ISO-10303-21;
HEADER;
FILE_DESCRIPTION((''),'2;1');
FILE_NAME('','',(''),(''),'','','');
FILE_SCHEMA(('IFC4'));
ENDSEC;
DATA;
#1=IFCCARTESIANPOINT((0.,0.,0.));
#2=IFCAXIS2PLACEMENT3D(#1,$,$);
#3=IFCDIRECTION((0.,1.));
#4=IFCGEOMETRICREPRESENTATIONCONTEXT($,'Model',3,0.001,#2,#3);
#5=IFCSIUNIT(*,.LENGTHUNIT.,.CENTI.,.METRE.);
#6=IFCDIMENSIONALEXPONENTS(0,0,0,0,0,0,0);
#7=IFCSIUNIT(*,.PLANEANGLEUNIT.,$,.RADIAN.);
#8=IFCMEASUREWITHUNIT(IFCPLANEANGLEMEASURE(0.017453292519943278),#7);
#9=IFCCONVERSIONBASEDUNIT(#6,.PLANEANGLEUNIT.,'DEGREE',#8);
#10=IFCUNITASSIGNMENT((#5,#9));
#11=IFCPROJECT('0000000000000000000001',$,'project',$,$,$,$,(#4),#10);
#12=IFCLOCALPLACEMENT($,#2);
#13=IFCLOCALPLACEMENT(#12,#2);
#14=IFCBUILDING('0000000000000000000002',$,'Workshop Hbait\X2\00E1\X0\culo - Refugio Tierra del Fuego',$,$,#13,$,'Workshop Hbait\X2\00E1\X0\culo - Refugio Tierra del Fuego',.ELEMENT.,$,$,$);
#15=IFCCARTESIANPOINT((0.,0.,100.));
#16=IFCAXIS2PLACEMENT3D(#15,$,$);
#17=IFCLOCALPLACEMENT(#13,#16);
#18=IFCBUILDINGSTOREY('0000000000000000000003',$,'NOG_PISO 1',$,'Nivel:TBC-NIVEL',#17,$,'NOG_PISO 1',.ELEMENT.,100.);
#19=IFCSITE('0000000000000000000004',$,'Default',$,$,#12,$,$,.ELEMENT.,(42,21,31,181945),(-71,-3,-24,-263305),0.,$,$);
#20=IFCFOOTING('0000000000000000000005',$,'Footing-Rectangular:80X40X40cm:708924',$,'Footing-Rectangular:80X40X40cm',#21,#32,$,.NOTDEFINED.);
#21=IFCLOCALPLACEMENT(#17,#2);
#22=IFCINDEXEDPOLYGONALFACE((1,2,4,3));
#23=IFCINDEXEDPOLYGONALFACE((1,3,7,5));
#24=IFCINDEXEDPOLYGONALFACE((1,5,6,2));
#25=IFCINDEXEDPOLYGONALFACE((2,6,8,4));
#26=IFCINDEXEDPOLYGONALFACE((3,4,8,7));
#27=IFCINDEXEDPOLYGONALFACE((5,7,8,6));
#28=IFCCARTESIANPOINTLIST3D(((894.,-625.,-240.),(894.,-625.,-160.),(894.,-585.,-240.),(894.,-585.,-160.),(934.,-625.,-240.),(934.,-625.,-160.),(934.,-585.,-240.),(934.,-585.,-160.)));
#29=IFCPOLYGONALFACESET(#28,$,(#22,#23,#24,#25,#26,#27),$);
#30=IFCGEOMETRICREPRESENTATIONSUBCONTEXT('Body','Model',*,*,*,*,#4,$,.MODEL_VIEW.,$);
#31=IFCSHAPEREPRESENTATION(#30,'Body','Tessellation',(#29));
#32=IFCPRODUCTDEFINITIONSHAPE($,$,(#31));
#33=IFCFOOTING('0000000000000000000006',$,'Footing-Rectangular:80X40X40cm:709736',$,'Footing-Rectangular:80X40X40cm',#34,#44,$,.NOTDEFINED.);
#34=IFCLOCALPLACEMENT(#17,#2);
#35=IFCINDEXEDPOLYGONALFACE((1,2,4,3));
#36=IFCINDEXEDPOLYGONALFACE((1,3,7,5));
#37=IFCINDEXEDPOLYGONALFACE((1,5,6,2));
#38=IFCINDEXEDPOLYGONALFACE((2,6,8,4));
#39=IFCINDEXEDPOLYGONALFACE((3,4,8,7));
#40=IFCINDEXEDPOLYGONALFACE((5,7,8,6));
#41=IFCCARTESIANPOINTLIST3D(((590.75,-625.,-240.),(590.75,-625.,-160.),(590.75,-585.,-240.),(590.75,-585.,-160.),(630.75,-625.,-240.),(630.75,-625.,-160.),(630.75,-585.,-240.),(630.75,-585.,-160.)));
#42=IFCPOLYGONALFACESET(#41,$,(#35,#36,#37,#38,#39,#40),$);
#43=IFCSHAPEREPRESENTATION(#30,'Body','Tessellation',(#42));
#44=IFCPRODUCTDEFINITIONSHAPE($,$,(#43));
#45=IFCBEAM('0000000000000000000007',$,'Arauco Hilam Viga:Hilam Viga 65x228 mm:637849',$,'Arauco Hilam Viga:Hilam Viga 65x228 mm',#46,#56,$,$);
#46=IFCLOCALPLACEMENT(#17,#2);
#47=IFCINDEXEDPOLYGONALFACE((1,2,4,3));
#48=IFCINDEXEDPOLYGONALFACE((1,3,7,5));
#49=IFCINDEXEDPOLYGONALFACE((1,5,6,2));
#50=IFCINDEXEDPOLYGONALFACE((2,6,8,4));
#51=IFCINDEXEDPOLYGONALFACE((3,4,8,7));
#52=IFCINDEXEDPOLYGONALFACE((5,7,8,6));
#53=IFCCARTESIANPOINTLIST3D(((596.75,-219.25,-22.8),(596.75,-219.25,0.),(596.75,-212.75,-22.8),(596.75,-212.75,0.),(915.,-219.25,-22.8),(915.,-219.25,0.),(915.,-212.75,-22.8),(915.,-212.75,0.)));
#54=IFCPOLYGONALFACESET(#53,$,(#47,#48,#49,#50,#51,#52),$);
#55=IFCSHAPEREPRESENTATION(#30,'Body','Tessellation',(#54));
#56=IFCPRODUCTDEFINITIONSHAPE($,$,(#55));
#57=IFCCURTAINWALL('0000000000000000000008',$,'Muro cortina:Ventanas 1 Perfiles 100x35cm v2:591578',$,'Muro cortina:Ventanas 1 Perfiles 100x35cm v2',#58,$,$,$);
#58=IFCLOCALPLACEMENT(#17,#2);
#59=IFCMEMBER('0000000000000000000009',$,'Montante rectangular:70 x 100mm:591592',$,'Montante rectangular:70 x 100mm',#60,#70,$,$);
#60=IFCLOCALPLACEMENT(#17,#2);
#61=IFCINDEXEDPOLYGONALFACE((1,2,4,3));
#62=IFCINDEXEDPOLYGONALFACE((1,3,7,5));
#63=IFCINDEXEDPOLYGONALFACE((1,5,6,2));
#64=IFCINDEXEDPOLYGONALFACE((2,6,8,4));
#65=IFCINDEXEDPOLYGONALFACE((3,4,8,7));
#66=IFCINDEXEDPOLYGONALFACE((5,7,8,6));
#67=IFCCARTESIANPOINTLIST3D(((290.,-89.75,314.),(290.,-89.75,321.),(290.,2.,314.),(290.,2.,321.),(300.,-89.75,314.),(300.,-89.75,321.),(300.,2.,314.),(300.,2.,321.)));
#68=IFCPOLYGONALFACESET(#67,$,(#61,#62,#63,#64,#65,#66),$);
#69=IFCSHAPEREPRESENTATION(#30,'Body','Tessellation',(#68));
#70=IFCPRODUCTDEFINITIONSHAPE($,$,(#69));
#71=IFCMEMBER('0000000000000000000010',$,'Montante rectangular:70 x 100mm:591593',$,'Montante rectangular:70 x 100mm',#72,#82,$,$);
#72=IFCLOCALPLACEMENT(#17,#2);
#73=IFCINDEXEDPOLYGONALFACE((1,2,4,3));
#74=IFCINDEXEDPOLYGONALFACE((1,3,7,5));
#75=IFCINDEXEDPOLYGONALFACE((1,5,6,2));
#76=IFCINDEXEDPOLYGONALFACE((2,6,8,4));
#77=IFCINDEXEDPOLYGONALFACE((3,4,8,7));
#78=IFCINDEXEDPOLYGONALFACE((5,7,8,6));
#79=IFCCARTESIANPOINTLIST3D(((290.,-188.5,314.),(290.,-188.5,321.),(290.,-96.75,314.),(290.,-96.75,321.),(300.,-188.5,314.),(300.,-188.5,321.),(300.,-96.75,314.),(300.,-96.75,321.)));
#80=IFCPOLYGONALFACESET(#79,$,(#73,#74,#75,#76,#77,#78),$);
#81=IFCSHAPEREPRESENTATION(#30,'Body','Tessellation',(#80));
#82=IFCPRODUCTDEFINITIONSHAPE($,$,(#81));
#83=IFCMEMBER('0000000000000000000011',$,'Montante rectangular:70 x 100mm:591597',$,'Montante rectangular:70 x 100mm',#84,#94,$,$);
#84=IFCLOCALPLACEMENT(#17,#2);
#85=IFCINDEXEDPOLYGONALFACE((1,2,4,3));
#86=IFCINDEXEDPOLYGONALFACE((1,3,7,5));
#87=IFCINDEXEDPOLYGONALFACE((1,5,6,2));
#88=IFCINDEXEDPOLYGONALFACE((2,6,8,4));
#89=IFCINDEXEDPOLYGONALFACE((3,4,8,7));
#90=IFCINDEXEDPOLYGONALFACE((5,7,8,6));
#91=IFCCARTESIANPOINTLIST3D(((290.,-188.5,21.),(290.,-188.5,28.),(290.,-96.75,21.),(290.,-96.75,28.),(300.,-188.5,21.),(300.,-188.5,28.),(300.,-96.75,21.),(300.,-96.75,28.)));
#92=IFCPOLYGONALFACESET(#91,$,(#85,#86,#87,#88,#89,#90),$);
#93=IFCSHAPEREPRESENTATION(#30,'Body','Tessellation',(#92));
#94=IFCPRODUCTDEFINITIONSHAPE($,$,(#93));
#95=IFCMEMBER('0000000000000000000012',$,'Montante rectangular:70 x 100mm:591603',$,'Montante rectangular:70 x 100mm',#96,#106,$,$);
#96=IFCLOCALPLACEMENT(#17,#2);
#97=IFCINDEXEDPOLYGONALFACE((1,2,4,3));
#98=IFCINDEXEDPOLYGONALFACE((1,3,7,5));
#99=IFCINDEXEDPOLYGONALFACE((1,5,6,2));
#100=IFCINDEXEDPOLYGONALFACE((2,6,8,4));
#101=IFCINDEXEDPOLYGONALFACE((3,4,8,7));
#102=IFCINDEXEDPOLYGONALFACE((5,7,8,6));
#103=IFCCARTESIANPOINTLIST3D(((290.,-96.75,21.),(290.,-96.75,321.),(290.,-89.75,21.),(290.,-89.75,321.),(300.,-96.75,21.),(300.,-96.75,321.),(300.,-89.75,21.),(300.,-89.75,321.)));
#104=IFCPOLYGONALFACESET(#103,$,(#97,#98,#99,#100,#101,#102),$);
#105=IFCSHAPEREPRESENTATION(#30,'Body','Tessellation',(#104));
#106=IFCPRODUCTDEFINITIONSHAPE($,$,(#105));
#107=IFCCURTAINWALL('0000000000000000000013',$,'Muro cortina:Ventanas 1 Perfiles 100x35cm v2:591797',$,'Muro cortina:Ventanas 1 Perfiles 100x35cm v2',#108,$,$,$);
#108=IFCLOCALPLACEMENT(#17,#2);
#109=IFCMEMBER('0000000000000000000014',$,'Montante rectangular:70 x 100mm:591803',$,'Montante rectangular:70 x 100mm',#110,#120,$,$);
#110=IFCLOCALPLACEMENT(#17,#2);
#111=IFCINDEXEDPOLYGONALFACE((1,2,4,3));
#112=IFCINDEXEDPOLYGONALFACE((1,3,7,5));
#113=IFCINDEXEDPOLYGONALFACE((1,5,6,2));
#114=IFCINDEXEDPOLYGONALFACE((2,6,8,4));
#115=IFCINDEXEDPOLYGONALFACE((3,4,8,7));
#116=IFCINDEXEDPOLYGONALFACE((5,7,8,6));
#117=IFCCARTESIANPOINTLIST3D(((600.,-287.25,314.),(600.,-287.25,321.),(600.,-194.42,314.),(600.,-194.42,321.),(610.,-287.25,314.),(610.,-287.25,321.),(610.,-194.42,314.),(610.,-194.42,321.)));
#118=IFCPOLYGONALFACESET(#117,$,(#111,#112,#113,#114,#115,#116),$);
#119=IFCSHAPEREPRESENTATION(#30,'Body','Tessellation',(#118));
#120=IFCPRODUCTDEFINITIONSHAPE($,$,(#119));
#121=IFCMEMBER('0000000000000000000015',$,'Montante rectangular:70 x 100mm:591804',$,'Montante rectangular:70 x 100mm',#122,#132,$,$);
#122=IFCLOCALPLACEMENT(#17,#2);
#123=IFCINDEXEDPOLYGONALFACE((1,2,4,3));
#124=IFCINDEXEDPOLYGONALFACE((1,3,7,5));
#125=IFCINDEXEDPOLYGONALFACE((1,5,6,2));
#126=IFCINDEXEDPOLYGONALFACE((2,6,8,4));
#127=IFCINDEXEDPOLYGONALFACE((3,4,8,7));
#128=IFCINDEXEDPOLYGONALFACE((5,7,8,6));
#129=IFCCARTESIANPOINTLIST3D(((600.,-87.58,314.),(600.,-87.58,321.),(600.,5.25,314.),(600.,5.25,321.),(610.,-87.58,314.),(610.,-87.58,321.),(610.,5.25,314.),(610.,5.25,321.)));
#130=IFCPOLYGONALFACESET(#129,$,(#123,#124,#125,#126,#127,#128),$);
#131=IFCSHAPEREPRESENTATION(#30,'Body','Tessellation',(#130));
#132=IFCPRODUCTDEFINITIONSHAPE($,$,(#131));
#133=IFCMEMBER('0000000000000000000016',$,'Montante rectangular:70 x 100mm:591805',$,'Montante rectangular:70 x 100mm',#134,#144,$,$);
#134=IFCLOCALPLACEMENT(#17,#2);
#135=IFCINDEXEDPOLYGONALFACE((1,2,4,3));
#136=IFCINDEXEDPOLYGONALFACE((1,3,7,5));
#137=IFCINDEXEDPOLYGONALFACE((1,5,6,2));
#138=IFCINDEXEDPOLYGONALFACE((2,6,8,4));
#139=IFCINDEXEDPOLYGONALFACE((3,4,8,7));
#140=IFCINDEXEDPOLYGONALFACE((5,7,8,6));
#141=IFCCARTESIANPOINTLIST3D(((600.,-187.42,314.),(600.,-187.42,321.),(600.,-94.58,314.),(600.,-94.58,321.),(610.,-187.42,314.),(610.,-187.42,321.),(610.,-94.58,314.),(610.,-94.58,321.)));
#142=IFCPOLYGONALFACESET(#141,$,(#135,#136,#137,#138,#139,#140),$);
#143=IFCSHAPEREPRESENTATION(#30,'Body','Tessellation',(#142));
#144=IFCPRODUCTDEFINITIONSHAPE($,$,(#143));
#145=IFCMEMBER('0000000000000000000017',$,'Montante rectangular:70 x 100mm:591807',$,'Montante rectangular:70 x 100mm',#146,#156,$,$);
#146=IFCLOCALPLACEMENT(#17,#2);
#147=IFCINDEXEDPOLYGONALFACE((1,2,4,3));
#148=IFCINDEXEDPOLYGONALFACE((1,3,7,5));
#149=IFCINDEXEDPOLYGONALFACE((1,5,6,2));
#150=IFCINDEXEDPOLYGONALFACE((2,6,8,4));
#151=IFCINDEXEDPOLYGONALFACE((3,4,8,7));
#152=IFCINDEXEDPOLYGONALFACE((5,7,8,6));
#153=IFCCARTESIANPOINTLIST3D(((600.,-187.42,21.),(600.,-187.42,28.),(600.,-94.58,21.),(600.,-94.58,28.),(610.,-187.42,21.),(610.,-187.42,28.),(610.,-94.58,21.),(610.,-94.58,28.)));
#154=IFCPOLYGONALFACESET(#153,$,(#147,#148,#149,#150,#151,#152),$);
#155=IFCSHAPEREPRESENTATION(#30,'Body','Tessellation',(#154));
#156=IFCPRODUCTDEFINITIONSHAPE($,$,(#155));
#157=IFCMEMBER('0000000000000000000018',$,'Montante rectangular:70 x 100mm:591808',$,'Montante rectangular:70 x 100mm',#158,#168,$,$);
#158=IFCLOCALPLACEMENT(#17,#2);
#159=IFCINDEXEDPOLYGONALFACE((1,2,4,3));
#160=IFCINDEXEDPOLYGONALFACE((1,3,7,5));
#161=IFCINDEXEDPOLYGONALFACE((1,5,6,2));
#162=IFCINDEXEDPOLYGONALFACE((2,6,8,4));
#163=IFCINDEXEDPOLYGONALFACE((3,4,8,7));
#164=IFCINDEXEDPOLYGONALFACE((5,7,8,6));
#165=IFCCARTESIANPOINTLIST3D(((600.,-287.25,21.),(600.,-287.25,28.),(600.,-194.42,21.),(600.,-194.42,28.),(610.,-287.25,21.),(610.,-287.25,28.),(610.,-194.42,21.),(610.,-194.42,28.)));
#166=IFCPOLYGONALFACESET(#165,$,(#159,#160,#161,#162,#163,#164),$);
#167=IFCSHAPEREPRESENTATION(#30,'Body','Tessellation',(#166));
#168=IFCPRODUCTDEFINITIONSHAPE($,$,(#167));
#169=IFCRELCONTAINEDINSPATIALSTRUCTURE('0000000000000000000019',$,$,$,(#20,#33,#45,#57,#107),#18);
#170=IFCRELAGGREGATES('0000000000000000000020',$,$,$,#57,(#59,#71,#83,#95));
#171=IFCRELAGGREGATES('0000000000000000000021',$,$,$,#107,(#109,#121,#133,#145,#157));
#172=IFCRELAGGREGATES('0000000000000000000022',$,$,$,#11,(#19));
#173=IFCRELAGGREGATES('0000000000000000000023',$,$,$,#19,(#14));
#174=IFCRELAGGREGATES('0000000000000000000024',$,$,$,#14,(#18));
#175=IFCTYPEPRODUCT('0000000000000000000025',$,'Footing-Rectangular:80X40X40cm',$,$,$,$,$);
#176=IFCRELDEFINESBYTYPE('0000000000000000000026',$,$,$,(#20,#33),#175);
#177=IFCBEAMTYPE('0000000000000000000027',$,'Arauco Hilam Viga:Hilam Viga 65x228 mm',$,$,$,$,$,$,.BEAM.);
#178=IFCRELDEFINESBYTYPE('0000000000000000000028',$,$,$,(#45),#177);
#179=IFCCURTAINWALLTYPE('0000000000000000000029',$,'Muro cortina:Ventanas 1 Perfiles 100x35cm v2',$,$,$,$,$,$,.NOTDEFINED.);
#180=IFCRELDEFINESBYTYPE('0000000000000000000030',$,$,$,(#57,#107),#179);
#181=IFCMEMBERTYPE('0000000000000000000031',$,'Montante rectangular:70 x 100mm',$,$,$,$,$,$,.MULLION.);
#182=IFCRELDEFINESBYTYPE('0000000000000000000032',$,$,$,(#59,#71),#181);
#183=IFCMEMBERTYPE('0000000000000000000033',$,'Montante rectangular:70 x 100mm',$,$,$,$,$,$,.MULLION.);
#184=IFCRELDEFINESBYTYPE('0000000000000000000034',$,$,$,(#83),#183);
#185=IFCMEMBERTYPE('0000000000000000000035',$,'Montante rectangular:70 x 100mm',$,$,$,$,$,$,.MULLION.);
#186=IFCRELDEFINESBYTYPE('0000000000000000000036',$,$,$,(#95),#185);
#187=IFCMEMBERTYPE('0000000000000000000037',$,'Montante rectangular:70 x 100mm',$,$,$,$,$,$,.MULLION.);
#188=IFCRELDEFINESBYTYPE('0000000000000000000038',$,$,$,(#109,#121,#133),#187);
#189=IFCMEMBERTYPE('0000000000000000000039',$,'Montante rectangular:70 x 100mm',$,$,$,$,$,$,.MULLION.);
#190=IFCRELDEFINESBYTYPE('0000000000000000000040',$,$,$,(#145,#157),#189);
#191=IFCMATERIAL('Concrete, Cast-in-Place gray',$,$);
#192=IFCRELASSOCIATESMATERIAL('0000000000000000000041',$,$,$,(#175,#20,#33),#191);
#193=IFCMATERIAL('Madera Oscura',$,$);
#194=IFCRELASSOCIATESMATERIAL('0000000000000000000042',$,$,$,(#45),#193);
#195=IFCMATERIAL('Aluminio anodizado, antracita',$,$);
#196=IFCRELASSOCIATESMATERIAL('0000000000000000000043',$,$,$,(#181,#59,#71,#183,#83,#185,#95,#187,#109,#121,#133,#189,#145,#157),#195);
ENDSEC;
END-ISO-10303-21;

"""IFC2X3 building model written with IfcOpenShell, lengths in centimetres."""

from ifc_helpers import new_model, entity, si_unit, converted_unit, direction, frame, frame_2d, origin, origin_2d_with_axis, place, context, subcontext, project, spatial, rectangle, extrude, source, transform, mapped, material, type_object, type_shapes, element, aggregate, save


model = new_model("IFC2X3")

# Units and contexts
model_context = context("Model", 3, precision=0.001, world=origin(), true_north=direction((0.0, 1.0)))
body_context = subcontext(model_context, "Body", "Model", "MODEL_VIEW")
ifc_project = project(units=[si_unit("LENGTHUNIT", "METRE", prefix="CENTI"), converted_unit("PLANEANGLEUNIT", "DEGREE", entity("IfcPlaneAngleMeasure", 0.017453292519943278), si_unit("PLANEANGLEUNIT", "RADIAN"), dimensions=[0, 0, 0, 0, 0, 0, 0])], contexts=[model_context])

# Site, building, storey
site_placement = place(None, origin())
site = spatial("IfcSite", under=ifc_project, at=site_placement, Name="Default", CompositionType="ELEMENT", RefLatitude=(42, 21, 31, 181945), RefLongitude=(-71, -3, -24, -263305), RefElevation=0.0)
building_placement = place(site_placement, origin())
building = spatial("IfcBuilding", under=site, at=building_placement, Name="Workshop Hbaitáculo - Refugio Tierra del Fuego", LongName="Workshop Hbaitáculo - Refugio Tierra del Fuego", CompositionType="ELEMENT")
storey_placement = place(building_placement, frame((0.0, 0.0, 100.0)))
storey = spatial("IfcBuildingStorey", under=building, at=storey_placement, Name="NOG_PISO 1", ObjectType="Nivel:TBC-NIVEL", LongName="NOG_PISO 1", CompositionType="ELEMENT", Elevation=100.0)

# Footings
ifc_material_1 = material(Name="Concrete, Cast-in-Place gray")
type_product = type_object("IfcTypeProduct", Name="Footing-Rectangular:80X40X40cm", material=ifc_material_1)
shared_shape_1 = source(origin(), body_context, "Body", "SweptSolid", [
    extrude(rectangle(XDim=40.0, YDim=40.0, at=origin_2d_with_axis()), frame((0.0, 0.0, -80.0), z_axis=(0.0, 0.0, 1.0), x_axis=(-1.0, 0.0, 0.0)), (0.0, 0.0, 1.0), 80.0),
])
type_shapes(type_product, [shared_shape_1])
for number, where, name in (
    (1, (914.0, -605.0, -160.0), "Footing-Rectangular:80X40X40cm:708924"),
    (2, (610.75, -605.0, -160.0), "Footing-Rectangular:80X40X40cm:709736"),
):
    element("IfcFooting", number, at=place(storey_placement, frame(where)), inside=storey, type_object=type_product, material=ifc_material_1, Name=name, ObjectType="Footing-Rectangular:80X40X40cm", PredefinedType="NOTDEFINED", context=body_context, shape_type="MappedRepresentation", body=[
        mapped(shared_shape_1, transform((0.0, 0.0, 0.0), scale=1.0)),
    ])

# Beam
ifc_material_2 = material(Name="Madera Oscura")
beam_type = type_object("IfcBeamType", Name="Arauco Hilam Viga:Hilam Viga 65x228 mm", PredefinedType="BEAM")
beam_1_placement = place(storey_placement, frame((596.75, -216.0, 0.0)))
element("IfcBeam", 3, at=beam_1_placement, inside=storey, type_object=beam_type, material=ifc_material_2, Name="Arauco Hilam Viga:Hilam Viga 65x228 mm:637849", ObjectType="Arauco Hilam Viga:Hilam Viga 65x228 mm", context=body_context, shape_type="SweptSolid", body=[
    extrude(rectangle(XDim=22.8, YDim=6.5, at=origin_2d_with_axis()), frame((0.0, 0.0, -11.4), z_axis=(1.0, 0.0, 0.0), x_axis=(0.0, 0.0, -1.0)), (0.0, 0.0, 1.0), 318.25),
])

# Curtain walls, members
curtain_wall_type = type_object("IfcCurtainWallType", Name="Muro cortina:Ventanas 1 Perfiles 100x35cm v2", PredefinedType="NOTDEFINED")
curtain_wall_1_placement = place(storey_placement, frame((0.0, 0.0, -100.0)))
curtain_wall_1 = element("IfcCurtainWall", 4, at=curtain_wall_1_placement, inside=storey, type_object=curtain_wall_type, Name="Muro cortina:Ventanas 1 Perfiles 100x35cm v2:591578", ObjectType="Muro cortina:Ventanas 1 Perfiles 100x35cm v2")
ifc_material_3 = material(Name="Aluminio anodizado, antracita")
member_type_1 = type_object("IfcMemberType", Name="Montante rectangular:70 x 100mm", PredefinedType="MULLION", material=ifc_material_3)
shared_shape_2 = source(origin(), body_context, "Body", "SweptSolid", [
    extrude(rectangle(XDim=7.0, YDim=10.0, at=origin_2d_with_axis()), frame((-3.5, 0.0, -91.75), z_axis=(0.0, 0.0, 1.0), x_axis=(-1.0, 0.0, 0.0)), (0.0, 0.0, 1.0), 91.75),
])
type_shapes(member_type_1, [shared_shape_2])
member_1_placement = place(curtain_wall_1_placement, frame((295.0, -89.75, 421.0), z_axis=(0.0, -1.0, 0.0), x_axis=(0.0, 0.0, 1.0)))
member_1 = element("IfcMember", 5, at=member_1_placement, type_object=member_type_1, material=ifc_material_3, Name="Montante rectangular:70 x 100mm:591592", ObjectType="Montante rectangular:70 x 100mm", context=body_context, shape_type="MappedRepresentation", body=[
    mapped(shared_shape_2, transform((0.0, 0.0, 0.0), scale=1.0)),
])
member_2_placement = place(curtain_wall_1_placement, frame((295.0, -188.5, 421.0), z_axis=(0.0, -1.0, 0.0), x_axis=(0.0, 0.0, 1.0)))
member_2 = element("IfcMember", 6, at=member_2_placement, type_object=member_type_1, material=ifc_material_3, Name="Montante rectangular:70 x 100mm:591593", ObjectType="Montante rectangular:70 x 100mm", context=body_context, shape_type="MappedRepresentation", body=[
    mapped(shared_shape_2, transform((0.0, 0.0, 0.0), scale=1.0)),
])
member_type_2 = type_object("IfcMemberType", Name="Montante rectangular:70 x 100mm", PredefinedType="MULLION", material=ifc_material_3)
shared_shape_3 = source(origin(), body_context, "Body", "SweptSolid", [
    extrude(rectangle(XDim=7.0, YDim=10.0, at=origin_2d_with_axis()), frame((-3.5, 0.0, -91.75), z_axis=(0.0, 0.0, 1.0), x_axis=(-1.0, 0.0, 0.0)), (0.0, 0.0, 1.0), 91.75),
])
type_shapes(member_type_2, [shared_shape_3])
member_3_placement = place(curtain_wall_1_placement, frame((295.0, -96.75, 121.0), z_axis=(0.0, 1.0, 0.0), x_axis=(0.0, 0.0, -1.0)))
member_3 = element("IfcMember", 7, at=member_3_placement, type_object=member_type_2, material=ifc_material_3, Name="Montante rectangular:70 x 100mm:591597", ObjectType="Montante rectangular:70 x 100mm", context=body_context, shape_type="MappedRepresentation", body=[
    mapped(shared_shape_3, transform((0.0, 0.0, 0.0), scale=1.0)),
])
member_type_3 = type_object("IfcMemberType", Name="Montante rectangular:70 x 100mm", PredefinedType="MULLION", material=ifc_material_3)
shared_shape_4 = source(origin(), body_context, "Body", "SweptSolid", [
    extrude(rectangle(XDim=7.0, YDim=10.0, at=frame_2d((0.0, 0.0), x_axis=(1.0, 0.0))), frame((0.0, 0.0, -300.0), z_axis=(0.0, 0.0, 1.0), x_axis=(-1.0, 0.0, 0.0)), (0.0, 0.0, 1.0), 300.0),
])
type_shapes(member_type_3, [shared_shape_4])
member_4_placement = place(curtain_wall_1_placement, frame((295.0, -93.25, 121.0), z_axis=(0.0, 0.0, -1.0), x_axis=(0.0, -1.0, 0.0)))
member_4 = element("IfcMember", 8, at=member_4_placement, type_object=member_type_3, material=ifc_material_3, Name="Montante rectangular:70 x 100mm:591603", ObjectType="Montante rectangular:70 x 100mm", context=body_context, shape_type="MappedRepresentation", body=[
    mapped(shared_shape_4, transform((0.0, 0.0, 0.0), scale=1.0)),
])
curtain_wall_2_placement = place(storey_placement, frame((0.0, 0.0, -100.0)))
curtain_wall_2 = element("IfcCurtainWall", 9, at=curtain_wall_2_placement, inside=storey, type_object=curtain_wall_type, Name="Muro cortina:Ventanas 1 Perfiles 100x35cm v2:591797", ObjectType="Muro cortina:Ventanas 1 Perfiles 100x35cm v2")
member_type_4 = type_object("IfcMemberType", Name="Montante rectangular:70 x 100mm", PredefinedType="MULLION", material=ifc_material_3)
shared_shape_5 = source(origin(), body_context, "Body", "SweptSolid", [
    extrude(rectangle(XDim=7.0, YDim=10.0, at=origin_2d_with_axis()), frame((-3.5, 0.0, -92.83), z_axis=(0.0, 0.0, 1.0), x_axis=(-1.0, 0.0, 0.0)), (0.0, 0.0, 1.0), 92.83),
])
type_shapes(member_type_4, [shared_shape_5])
member_5_placement = place(curtain_wall_2_placement, frame((605.0, -287.25, 421.0), z_axis=(0.0, -1.0, 0.0), x_axis=(0.0, 0.0, 1.0)))
member_5 = element("IfcMember", 10, at=member_5_placement, type_object=member_type_4, material=ifc_material_3, Name="Montante rectangular:70 x 100mm:591803", ObjectType="Montante rectangular:70 x 100mm", context=body_context, shape_type="MappedRepresentation", body=[
    mapped(shared_shape_5, transform((0.0, 0.0, 0.0), scale=1.0)),
])
member_6_placement = place(curtain_wall_2_placement, frame((605.0, -87.58, 421.0), z_axis=(0.0, -1.0, 0.0), x_axis=(0.0, 0.0, 1.0)))
member_6 = element("IfcMember", 11, at=member_6_placement, type_object=member_type_4, material=ifc_material_3, Name="Montante rectangular:70 x 100mm:591804", ObjectType="Montante rectangular:70 x 100mm", context=body_context, shape_type="MappedRepresentation", body=[
    mapped(shared_shape_5, transform((0.0, 0.0, 0.0), scale=1.0)),
])
member_7_placement = place(curtain_wall_2_placement, frame((605.0, -187.42, 421.0), z_axis=(0.0, -1.0, 0.0), x_axis=(0.0, 0.0, 1.0)))
member_7 = element("IfcMember", 12, at=member_7_placement, type_object=member_type_4, material=ifc_material_3, Name="Montante rectangular:70 x 100mm:591805", ObjectType="Montante rectangular:70 x 100mm", context=body_context, shape_type="MappedRepresentation", body=[
    mapped(shared_shape_5, transform((0.0, 0.0, 0.0), scale=1.0)),
])
member_type_5 = type_object("IfcMemberType", Name="Montante rectangular:70 x 100mm", PredefinedType="MULLION", material=ifc_material_3)
shared_shape_6 = source(origin(), body_context, "Body", "SweptSolid", [
    extrude(rectangle(XDim=7.0, YDim=10.0, at=origin_2d_with_axis()), frame((-3.5, 0.0, -92.83), z_axis=(0.0, 0.0, 1.0), x_axis=(-1.0, 0.0, 0.0)), (0.0, 0.0, 1.0), 92.83),
])
type_shapes(member_type_5, [shared_shape_6])
member_8_placement = place(curtain_wall_2_placement, frame((605.0, -94.58, 121.0), z_axis=(0.0, 1.0, 0.0), x_axis=(0.0, 0.0, -1.0)))
member_8 = element("IfcMember", 13, at=member_8_placement, type_object=member_type_5, material=ifc_material_3, Name="Montante rectangular:70 x 100mm:591807", ObjectType="Montante rectangular:70 x 100mm", context=body_context, shape_type="MappedRepresentation", body=[
    mapped(shared_shape_6, transform((0.0, 0.0, 0.0), scale=1.0)),
])
member_9_placement = place(curtain_wall_2_placement, frame((605.0, -194.42, 121.0), z_axis=(0.0, 1.0, 0.0), x_axis=(0.0, 0.0, -1.0)))
member_9 = element("IfcMember", 14, at=member_9_placement, type_object=member_type_5, material=ifc_material_3, Name="Montante rectangular:70 x 100mm:591808", ObjectType="Montante rectangular:70 x 100mm", context=body_context, shape_type="MappedRepresentation", body=[
    mapped(shared_shape_6, transform((0.0, 0.0, 0.0), scale=1.0)),
])

aggregate(curtain_wall_1, [member_1, member_2, member_3, member_4])
aggregate(curtain_wall_2, [member_5, member_6, member_7, member_8, member_9])

save(model, "model.ifc")
